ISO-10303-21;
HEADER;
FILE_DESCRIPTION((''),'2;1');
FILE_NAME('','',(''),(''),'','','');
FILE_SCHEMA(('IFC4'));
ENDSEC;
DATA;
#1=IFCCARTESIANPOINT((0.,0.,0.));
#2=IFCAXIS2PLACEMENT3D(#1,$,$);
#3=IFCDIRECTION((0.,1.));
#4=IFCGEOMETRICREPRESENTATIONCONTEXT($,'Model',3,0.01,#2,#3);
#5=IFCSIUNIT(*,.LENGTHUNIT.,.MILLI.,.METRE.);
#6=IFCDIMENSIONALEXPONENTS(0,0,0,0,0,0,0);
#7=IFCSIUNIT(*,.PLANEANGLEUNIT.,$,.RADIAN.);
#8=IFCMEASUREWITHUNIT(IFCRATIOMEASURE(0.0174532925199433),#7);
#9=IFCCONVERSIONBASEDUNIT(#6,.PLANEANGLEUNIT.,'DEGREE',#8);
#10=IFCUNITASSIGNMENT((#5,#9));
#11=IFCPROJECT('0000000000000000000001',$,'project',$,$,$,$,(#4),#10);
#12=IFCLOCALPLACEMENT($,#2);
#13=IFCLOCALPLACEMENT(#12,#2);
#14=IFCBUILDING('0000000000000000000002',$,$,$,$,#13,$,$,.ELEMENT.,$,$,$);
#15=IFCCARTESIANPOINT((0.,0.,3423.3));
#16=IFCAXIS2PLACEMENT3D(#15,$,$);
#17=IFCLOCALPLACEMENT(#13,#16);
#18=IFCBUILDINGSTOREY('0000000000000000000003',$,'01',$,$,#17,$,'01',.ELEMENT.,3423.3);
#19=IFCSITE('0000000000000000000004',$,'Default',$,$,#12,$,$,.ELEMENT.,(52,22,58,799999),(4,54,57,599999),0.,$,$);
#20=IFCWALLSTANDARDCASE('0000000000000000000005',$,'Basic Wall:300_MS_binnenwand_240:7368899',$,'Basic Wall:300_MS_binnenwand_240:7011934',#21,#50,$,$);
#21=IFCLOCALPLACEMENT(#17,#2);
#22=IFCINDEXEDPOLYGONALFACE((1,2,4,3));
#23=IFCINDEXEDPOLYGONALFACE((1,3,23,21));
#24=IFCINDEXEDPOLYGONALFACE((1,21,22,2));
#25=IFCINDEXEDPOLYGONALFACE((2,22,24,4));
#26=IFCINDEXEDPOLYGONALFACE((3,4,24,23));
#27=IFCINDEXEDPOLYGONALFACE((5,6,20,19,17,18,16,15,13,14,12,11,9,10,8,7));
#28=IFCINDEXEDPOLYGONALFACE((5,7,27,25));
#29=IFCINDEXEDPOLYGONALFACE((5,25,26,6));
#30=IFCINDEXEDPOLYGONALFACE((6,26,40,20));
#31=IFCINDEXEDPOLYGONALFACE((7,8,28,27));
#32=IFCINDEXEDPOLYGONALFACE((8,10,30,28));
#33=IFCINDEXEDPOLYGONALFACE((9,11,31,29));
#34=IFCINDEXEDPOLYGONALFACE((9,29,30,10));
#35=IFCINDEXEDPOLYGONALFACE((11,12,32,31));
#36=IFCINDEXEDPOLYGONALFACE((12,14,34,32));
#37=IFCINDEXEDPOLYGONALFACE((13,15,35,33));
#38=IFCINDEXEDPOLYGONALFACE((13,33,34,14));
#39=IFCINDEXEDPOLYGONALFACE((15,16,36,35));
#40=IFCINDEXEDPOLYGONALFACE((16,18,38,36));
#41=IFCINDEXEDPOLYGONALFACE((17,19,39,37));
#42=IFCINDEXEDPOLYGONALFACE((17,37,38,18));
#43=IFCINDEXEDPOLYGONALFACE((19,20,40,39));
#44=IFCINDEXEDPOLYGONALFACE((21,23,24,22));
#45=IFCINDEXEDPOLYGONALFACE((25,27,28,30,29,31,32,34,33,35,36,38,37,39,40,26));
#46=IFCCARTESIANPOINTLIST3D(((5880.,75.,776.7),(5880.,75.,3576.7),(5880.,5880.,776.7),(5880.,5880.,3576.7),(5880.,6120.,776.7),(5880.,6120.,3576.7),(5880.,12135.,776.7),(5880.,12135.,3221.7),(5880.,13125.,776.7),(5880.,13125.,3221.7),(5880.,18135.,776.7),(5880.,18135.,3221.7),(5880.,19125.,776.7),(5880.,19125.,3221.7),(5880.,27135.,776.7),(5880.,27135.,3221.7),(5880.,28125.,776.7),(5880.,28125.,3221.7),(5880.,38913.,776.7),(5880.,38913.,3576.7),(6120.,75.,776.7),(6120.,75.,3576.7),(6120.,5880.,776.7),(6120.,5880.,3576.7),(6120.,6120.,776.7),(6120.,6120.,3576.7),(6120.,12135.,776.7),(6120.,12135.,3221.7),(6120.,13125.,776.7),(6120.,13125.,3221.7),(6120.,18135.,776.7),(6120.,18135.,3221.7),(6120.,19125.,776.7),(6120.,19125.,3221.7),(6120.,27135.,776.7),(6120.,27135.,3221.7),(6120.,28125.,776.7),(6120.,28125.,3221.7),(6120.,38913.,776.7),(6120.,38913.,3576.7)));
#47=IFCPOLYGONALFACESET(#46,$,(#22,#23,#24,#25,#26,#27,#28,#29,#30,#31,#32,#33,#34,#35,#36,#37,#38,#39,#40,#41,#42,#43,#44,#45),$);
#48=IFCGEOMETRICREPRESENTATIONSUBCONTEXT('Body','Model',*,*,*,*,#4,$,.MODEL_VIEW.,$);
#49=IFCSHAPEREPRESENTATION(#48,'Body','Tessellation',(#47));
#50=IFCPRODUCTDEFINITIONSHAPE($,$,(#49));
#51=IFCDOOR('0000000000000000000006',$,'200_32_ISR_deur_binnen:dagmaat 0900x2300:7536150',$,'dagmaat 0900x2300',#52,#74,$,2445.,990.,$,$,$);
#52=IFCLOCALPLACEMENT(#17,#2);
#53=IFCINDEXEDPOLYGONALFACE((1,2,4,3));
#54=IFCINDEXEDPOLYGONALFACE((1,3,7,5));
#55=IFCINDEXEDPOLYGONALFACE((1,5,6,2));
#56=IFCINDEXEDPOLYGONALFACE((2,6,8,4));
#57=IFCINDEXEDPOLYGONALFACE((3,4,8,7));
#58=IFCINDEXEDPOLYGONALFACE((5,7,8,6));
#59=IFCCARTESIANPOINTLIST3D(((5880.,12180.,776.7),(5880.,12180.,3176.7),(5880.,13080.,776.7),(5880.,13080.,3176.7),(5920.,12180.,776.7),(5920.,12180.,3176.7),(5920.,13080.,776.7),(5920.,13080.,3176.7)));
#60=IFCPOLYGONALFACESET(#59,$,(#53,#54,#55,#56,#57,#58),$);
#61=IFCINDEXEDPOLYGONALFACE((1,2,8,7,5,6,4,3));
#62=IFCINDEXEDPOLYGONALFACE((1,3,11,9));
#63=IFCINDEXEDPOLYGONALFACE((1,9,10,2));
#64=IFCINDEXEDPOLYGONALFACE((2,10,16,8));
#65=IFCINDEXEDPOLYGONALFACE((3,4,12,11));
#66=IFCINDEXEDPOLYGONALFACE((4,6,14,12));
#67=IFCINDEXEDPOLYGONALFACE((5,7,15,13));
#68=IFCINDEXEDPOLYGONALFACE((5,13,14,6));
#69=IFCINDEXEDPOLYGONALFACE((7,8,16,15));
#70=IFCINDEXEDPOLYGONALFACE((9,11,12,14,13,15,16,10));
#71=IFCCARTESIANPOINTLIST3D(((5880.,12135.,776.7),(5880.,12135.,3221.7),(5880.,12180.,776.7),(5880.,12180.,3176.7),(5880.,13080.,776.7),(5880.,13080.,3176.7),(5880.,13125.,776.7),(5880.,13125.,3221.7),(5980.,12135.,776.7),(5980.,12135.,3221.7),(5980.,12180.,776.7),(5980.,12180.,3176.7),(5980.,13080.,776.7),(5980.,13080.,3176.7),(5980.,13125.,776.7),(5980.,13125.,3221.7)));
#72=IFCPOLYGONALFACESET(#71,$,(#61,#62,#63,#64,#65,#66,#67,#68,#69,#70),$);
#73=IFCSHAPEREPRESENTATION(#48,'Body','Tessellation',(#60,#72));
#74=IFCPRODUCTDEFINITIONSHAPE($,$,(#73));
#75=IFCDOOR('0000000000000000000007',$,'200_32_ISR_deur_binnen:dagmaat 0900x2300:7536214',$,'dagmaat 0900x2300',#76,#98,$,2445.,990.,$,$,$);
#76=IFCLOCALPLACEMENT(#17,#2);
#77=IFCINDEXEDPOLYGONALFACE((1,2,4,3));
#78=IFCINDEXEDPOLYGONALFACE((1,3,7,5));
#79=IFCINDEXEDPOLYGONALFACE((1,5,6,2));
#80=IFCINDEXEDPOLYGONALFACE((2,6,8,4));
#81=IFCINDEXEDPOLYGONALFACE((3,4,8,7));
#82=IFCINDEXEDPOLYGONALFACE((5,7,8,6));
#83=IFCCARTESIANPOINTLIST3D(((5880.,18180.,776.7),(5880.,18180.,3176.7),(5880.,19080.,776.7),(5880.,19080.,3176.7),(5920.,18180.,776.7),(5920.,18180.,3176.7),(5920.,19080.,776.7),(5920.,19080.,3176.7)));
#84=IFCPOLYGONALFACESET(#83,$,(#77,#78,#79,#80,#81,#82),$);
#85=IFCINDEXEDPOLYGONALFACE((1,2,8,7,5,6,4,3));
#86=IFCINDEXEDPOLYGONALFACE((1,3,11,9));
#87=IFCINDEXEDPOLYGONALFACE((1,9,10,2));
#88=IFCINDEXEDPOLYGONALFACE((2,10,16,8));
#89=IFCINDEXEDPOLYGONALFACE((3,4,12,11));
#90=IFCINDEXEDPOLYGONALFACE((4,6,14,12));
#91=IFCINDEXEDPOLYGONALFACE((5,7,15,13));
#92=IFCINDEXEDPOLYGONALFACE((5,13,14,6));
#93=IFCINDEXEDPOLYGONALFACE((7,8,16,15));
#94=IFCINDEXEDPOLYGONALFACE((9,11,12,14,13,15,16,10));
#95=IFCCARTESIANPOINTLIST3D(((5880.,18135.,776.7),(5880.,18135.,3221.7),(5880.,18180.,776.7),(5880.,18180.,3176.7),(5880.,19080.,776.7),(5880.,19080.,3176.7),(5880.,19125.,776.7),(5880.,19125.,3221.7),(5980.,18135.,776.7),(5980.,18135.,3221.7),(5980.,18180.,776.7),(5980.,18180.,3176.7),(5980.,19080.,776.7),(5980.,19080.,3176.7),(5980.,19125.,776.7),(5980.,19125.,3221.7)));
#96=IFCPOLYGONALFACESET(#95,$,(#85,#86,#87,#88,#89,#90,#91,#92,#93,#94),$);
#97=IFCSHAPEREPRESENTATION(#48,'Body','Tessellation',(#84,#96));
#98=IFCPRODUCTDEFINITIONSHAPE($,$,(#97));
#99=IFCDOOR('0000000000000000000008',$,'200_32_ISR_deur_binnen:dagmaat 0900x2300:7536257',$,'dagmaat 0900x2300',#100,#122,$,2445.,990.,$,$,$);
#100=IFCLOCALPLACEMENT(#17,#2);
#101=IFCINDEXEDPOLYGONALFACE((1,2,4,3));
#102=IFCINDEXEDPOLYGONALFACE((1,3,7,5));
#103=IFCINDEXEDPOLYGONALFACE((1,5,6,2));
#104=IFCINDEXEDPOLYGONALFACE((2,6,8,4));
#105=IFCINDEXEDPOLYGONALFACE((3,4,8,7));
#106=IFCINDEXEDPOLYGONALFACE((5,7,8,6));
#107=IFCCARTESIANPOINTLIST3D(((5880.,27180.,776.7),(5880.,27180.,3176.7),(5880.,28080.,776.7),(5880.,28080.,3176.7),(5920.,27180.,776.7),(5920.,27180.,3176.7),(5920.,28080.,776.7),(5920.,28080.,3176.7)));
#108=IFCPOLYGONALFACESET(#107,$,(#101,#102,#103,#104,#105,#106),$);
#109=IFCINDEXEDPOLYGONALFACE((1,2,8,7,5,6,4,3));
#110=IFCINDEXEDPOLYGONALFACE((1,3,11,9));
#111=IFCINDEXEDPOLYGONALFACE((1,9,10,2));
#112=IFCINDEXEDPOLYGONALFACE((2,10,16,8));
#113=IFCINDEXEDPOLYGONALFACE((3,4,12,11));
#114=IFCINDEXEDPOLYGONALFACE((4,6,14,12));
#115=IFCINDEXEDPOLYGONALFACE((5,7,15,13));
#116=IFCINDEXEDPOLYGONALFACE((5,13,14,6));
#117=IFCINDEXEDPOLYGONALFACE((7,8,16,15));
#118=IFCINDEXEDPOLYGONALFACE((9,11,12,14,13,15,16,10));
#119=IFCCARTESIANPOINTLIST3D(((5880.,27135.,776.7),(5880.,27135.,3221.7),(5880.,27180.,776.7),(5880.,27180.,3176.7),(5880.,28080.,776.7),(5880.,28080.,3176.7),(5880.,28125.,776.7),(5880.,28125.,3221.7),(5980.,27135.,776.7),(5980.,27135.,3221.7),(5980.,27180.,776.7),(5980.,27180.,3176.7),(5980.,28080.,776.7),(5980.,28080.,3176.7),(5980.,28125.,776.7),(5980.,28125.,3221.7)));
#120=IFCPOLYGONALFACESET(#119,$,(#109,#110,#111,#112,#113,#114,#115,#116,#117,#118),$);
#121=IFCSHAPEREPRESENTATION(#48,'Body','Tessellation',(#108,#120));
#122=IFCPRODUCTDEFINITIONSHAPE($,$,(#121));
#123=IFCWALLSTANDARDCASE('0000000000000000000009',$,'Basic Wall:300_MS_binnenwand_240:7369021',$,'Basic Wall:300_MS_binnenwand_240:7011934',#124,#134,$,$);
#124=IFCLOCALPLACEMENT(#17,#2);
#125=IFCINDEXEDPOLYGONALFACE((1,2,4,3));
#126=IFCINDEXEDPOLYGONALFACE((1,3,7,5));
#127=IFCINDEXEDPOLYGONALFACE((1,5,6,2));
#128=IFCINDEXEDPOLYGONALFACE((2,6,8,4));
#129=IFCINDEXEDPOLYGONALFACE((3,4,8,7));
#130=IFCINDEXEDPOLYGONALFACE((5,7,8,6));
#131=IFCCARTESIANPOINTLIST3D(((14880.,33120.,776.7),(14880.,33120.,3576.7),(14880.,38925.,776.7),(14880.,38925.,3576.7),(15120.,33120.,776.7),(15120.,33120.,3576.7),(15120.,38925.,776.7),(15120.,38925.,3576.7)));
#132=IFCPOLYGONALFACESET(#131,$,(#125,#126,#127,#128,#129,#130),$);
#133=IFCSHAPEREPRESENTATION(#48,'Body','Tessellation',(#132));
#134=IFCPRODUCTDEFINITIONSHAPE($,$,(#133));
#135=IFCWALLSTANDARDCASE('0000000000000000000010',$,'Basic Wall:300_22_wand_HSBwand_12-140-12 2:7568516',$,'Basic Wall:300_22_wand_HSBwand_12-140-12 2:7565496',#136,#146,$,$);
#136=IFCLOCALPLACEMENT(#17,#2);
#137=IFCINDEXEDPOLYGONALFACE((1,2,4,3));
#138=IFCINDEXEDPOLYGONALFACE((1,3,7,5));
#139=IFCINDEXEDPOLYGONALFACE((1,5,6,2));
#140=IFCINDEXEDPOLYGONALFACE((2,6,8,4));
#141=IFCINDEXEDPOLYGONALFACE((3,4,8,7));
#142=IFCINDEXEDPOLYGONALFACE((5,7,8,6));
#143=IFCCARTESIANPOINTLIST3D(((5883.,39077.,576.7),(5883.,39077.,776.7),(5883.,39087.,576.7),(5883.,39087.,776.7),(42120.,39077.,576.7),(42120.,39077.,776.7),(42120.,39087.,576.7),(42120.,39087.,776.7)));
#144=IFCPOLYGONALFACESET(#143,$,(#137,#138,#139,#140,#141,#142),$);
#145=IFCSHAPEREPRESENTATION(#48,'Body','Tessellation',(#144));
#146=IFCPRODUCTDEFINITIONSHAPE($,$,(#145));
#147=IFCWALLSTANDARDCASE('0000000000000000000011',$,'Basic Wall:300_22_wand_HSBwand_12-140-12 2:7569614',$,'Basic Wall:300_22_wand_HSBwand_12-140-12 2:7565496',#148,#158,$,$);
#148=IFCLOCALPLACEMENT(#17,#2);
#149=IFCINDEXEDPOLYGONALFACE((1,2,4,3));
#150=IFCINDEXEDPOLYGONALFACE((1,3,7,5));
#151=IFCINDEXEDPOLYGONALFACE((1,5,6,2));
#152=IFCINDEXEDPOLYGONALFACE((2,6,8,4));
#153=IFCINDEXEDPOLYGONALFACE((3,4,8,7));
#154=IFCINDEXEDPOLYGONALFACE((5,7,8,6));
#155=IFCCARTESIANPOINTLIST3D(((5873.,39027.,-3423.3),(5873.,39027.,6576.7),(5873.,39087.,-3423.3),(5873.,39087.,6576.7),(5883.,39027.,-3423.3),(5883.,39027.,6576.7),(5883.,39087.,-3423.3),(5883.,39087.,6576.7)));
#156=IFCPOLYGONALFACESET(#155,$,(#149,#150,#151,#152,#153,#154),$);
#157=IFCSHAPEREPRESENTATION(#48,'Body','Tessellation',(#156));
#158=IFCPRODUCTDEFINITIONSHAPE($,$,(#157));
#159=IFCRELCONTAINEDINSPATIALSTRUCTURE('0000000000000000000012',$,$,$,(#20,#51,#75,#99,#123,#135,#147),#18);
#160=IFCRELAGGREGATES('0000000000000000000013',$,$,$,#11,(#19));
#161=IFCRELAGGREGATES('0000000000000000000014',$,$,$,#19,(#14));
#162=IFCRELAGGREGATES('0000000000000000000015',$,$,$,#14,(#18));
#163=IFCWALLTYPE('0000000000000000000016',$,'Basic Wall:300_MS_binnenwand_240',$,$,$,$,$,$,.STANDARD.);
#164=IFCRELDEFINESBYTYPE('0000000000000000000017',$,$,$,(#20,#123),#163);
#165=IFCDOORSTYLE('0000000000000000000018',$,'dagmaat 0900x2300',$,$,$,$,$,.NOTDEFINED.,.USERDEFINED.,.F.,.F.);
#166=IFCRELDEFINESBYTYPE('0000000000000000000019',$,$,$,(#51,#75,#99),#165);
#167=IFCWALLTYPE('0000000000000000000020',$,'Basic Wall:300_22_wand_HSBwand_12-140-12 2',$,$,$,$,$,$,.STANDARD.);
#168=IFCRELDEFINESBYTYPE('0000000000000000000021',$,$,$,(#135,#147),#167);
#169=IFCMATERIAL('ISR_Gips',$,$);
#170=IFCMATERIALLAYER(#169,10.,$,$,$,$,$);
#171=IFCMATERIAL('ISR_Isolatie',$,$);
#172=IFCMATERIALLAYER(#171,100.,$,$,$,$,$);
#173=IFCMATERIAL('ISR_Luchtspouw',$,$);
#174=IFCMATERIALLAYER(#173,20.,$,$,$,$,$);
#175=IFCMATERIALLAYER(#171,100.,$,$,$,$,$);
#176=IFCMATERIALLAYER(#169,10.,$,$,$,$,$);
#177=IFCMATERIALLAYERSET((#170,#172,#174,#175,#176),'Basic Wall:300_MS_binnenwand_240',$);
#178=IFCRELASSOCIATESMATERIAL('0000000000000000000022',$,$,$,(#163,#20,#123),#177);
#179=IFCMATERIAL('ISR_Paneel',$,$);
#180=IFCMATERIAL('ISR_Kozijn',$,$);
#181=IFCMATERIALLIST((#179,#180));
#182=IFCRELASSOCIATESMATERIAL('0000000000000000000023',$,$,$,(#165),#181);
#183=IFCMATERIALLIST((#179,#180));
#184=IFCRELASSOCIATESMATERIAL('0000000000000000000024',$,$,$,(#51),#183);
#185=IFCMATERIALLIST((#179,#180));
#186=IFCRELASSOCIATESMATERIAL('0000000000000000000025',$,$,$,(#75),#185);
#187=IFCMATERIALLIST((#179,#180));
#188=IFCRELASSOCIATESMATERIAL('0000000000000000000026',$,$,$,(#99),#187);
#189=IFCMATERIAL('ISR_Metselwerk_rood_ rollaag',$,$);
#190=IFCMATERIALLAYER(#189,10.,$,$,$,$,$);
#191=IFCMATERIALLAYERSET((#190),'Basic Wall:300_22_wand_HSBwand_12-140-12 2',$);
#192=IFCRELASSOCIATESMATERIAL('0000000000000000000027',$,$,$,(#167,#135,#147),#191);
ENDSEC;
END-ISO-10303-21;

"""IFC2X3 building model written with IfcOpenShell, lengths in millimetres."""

from ifc_helpers import new_model, entity, si_unit, converted_unit, direction, frame, frame_2d, origin, origin_2d_with_axis, place, context, subcontext, project, spatial, polyline, rectangle, outline, extrude, source, transform, mapped, material, material_list, layer, layer_set, layer_usage, type_object, type_shapes, element, fill, save


model = new_model("IFC2X3")

# Units and contexts
model_context = context("Model", 3, precision=0.01, world=origin(), true_north=direction((0.0, 1.0)))
body_context = subcontext(model_context, "Body", "Model", "MODEL_VIEW")
ifc_project = project(units=[si_unit("LENGTHUNIT", "METRE", prefix="MILLI"), converted_unit("PLANEANGLEUNIT", "DEGREE", entity("IfcRatioMeasure", 0.0174532925199433), si_unit("PLANEANGLEUNIT", "RADIAN"), dimensions=[0, 0, 0, 0, 0, 0, 0])], contexts=[model_context])

# Site, building, storey
site_placement = place(None, origin())
site = spatial("IfcSite", under=ifc_project, at=site_placement, Name="Default", CompositionType="ELEMENT", RefLatitude=(52, 22, 58, 799999), RefLongitude=(4, 54, 57, 599999), RefElevation=0.0)
building_placement = place(site_placement, origin())
building = spatial("IfcBuilding", under=site, at=building_placement, CompositionType="ELEMENT")
storey_placement = place(building_placement, frame((0.0, 0.0, 3423.3)))
storey = spatial("IfcBuildingStorey", under=building, at=storey_placement, Name="01", LongName="01", CompositionType="ELEMENT", Elevation=3423.3)

# Wall, openings, doors
ifc_material_1 = material(Name="ISR_Gips")
ifc_layer_1 = layer(ifc_material_1, 10.0)
ifc_material_2 = material(Name="ISR_Isolatie")
ifc_layer_2 = layer(ifc_material_2, 100.0)
ifc_material_3 = material(Name="ISR_Luchtspouw")
ifc_layer_3 = layer(ifc_material_3, 20.0)
ifc_layer_4 = layer(ifc_material_2, 100.0)
ifc_layer_5 = layer(ifc_material_1, 10.0)
ifc_layer_set_1 = layer_set([ifc_layer_1, ifc_layer_2, ifc_layer_3, ifc_layer_4, ifc_layer_5], Name="Basic Wall:300_MS_binnenwand_240")
ifc_layer_usage_1 = layer_usage(ifc_layer_set_1, "AXIS2", "NEGATIVE", 120.0)
wall_type_1 = type_object("IfcWallType", Name="Basic Wall:300_MS_binnenwand_240", PredefinedType="STANDARD", material=ifc_layer_set_1)
wall_1_placement = place(storey_placement, frame((6000.0, 38913.0, 776.7), z_axis=(0.0, 0.0, 1.0), x_axis=(0.0, -1.0, 0.0)))
wall_1 = element("IfcWallStandardCase", 1, at=wall_1_placement, inside=storey, type_object=wall_type_1, material=ifc_layer_usage_1, Name="Basic Wall:300_MS_binnenwand_240:7368899", ObjectType="Basic Wall:300_MS_binnenwand_240:7011934", context=body_context, shape_type="SweptSolid", body=[
    extrude(rectangle(XDim=38838.0, YDim=240.0, at=frame_2d((19419.0, 0.0), x_axis=(-1.0, 0.0))), origin(), (0.0, 0.0, 1.0), 2800.0),
])
opening_1_placement = place(storey_placement, frame((6000.0, 38913.0, 776.7), z_axis=(0.0, 0.0, 1.0), x_axis=(0.0, -1.0, 0.0)))
element("IfcOpeningElement", 2, at=opening_1_placement, cuts=wall_1, ObjectType="Opening", context=body_context, shape_type="SweptSolid", body=[
    extrude(rectangle(XDim=2800.0, YDim=240.0, at=origin_2d_with_axis()), frame((33033.0, 0.0, 1400.0), z_axis=(-1.0, 0.0, 0.0), x_axis=(0.0, 0.0, 1.0)), (0.0, 0.0, 1.0), 240.0),
])
opening_2_placement = place(wall_1_placement, frame((26778.0, 120.0, 0.0)))
opening_2 = element("IfcOpeningElement", 3, at=opening_2_placement, cuts=wall_1, ObjectType="Opening", context=body_context, shape_type="SweptSolid", body=[
    extrude(rectangle(XDim=2445.0, YDim=990.0, at=frame_2d((1222.5, 495.0), x_axis=(-1.0, 0.0))), frame((0.0, 0.0, 0.0), z_axis=(0.0, -1.0, 0.0), x_axis=(0.0, 0.0, 1.0)), (0.0, 0.0, 1.0), 240.0),
])
opening_3_placement = place(wall_1_placement, frame((20778.0, 120.0, 0.0)))
opening_3 = element("IfcOpeningElement", 4, at=opening_3_placement, cuts=wall_1, ObjectType="Opening", context=body_context, shape_type="SweptSolid", body=[
    extrude(rectangle(XDim=2445.0, YDim=990.0, at=frame_2d((1222.5, 495.0), x_axis=(-1.0, 0.0))), frame((0.0, 0.0, 0.0), z_axis=(0.0, -1.0, 0.0), x_axis=(0.0, 0.0, 1.0)), (0.0, 0.0, 1.0), 240.0),
])
opening_4_placement = place(wall_1_placement, frame((11778.0, 120.0, 0.0)))
opening_4 = element("IfcOpeningElement", 5, at=opening_4_placement, cuts=wall_1, ObjectType="Opening", context=body_context, shape_type="SweptSolid", body=[
    extrude(rectangle(XDim=2445.0, YDim=990.0, at=frame_2d((1222.5, 495.0), x_axis=(-1.0, 0.0))), frame((0.0, 0.0, 0.0), z_axis=(0.0, -1.0, 0.0), x_axis=(0.0, 0.0, 1.0)), (0.0, 0.0, 1.0), 240.0),
])
ifc_material_4 = material(Name="ISR_Paneel")
ifc_material_5 = material(Name="ISR_Kozijn")
ifc_material_list_1 = material_list([ifc_material_4, ifc_material_5])
ifc_material_list_2 = material_list([ifc_material_4, ifc_material_5])
door_style = type_object("IfcDoorStyle", Name="dagmaat 0900x2300", ConstructionType="USERDEFINED", OperationType="NOTDEFINED", ParameterTakesPrecedence=False, Sizeable=False, material=ifc_material_list_2)
shared_shape_1 = source(origin(), body_context, "Body", "SweptSolid", [
    extrude(rectangle(XDim=900.0, YDim=40.0, at=origin_2d_with_axis()), frame((495.0, 220.0, 0.0)), (0.0, 0.0, 1.0), 2400.0),
    extrude(outline(polyline([(-1211.2, -450.0), (-1211.2, -495.0), (1233.7, -495.0), (1233.7, 495.0), (-1211.2, 495.0), (-1211.2, 450.0), (1188.8, 450.0), (1188.8, -450.0), (-1211.2, -450.0)])), frame((495.0, 140.0, 1211.2), z_axis=(0.0, -1.0, 0.0), x_axis=(0.0, 0.0, 1.0)), (0.0, 0.0, -1.0), 100.0),
])
type_shapes(door_style, [shared_shape_1])
door_1_placement = place(opening_2_placement, frame((0.0, 0.0, 0.0), z_axis=(0.0, 0.0, 1.0), x_axis=(-1.0, 0.0, 0.0)))
door_1 = element("IfcDoor", 6, at=door_1_placement, inside=storey, type_object=door_style, material=ifc_material_list_1, Name="200_32_ISR_deur_binnen:dagmaat 0900x2300:7536150", ObjectType="dagmaat 0900x2300", OverallHeight=2445.0, OverallWidth=990.0, context=body_context, shape_type="MappedRepresentation", body=[
    mapped(shared_shape_1, transform((0.0, 0.0, 0.0), scale=1.0)),
])
fill(opening_2, door_1)
ifc_material_list_3 = material_list([ifc_material_4, ifc_material_5])
door_2_placement = place(opening_3_placement, frame((0.0, 0.0, 0.0), z_axis=(0.0, 0.0, 1.0), x_axis=(-1.0, 0.0, 0.0)))
door_2 = element("IfcDoor", 7, at=door_2_placement, inside=storey, type_object=door_style, material=ifc_material_list_3, Name="200_32_ISR_deur_binnen:dagmaat 0900x2300:7536214", ObjectType="dagmaat 0900x2300", OverallHeight=2445.0, OverallWidth=990.0, context=body_context, shape_type="MappedRepresentation", body=[
    mapped(shared_shape_1, transform((0.0, 0.0, 0.0), scale=1.0)),
])
fill(opening_3, door_2)
ifc_material_list_4 = material_list([ifc_material_4, ifc_material_5])
door_3_placement = place(opening_4_placement, frame((0.0, 0.0, 0.0), z_axis=(0.0, 0.0, 1.0), x_axis=(-1.0, 0.0, 0.0)))
door_3 = element("IfcDoor", 8, at=door_3_placement, inside=storey, type_object=door_style, material=ifc_material_list_4, Name="200_32_ISR_deur_binnen:dagmaat 0900x2300:7536257", ObjectType="dagmaat 0900x2300", OverallHeight=2445.0, OverallWidth=990.0, context=body_context, shape_type="MappedRepresentation", body=[
    mapped(shared_shape_1, transform((0.0, 0.0, 0.0), scale=1.0)),
])
fill(opening_4, door_3)

# Walls
ifc_layer_usage_2 = layer_usage(ifc_layer_set_1, "AXIS2", "POSITIVE", -120.0)
wall_2_placement = place(storey_placement, frame((15000.0, 33120.0, 776.7), z_axis=(0.0, 0.0, 1.0), x_axis=(0.0, 1.0, 0.0)))
element("IfcWallStandardCase", 9, at=wall_2_placement, inside=storey, type_object=wall_type_1, material=ifc_layer_usage_2, Name="Basic Wall:300_MS_binnenwand_240:7369021", ObjectType="Basic Wall:300_MS_binnenwand_240:7011934", context=body_context, shape_type="SweptSolid", body=[
    extrude(rectangle(XDim=5805.0, YDim=240.0, at=frame_2d((2902.5, 0.0), x_axis=(-1.0, 0.0))), origin(), (0.0, 0.0, 1.0), 2800.0),
])
ifc_material_6 = material(Name="ISR_Metselwerk_rood_ rollaag")
ifc_layer_6 = layer(ifc_material_6, 10.0)
ifc_layer_set_2 = layer_set([ifc_layer_6], Name="Basic Wall:300_22_wand_HSBwand_12-140-12 2")
ifc_layer_usage_3 = layer_usage(ifc_layer_set_2, "AXIS2", "NEGATIVE", 5.0)
wall_type_2 = type_object("IfcWallType", Name="Basic Wall:300_22_wand_HSBwand_12-140-12 2", PredefinedType="STANDARD", material=ifc_layer_set_2)
wall_3_placement = place(storey_placement, frame((5883.0, 39082.0, 576.7)))
element("IfcWallStandardCase", 10, at=wall_3_placement, inside=storey, type_object=wall_type_2, material=ifc_layer_usage_3, Name="Basic Wall:300_22_wand_HSBwand_12-140-12 2:7568516", ObjectType="Basic Wall:300_22_wand_HSBwand_12-140-12 2:7565496", context=body_context, shape_type="SweptSolid", body=[
    extrude(rectangle(XDim=36237.0, YDim=10.0, at=frame_2d((18118.5, 0.0), x_axis=(-1.0, 0.0))), origin(), (0.0, 0.0, 1.0), 200.0),
])
ifc_layer_usage_4 = layer_usage(ifc_layer_set_2, "AXIS2", "NEGATIVE", 5.0)
wall_4_placement = place(storey_placement, frame((5878.0, 39027.0, -3423.3), z_axis=(0.0, 0.0, 1.0), x_axis=(0.0, 1.0, 0.0)))
element("IfcWallStandardCase", 11, at=wall_4_placement, inside=storey, type_object=wall_type_2, material=ifc_layer_usage_4, Name="Basic Wall:300_22_wand_HSBwand_12-140-12 2:7569614", ObjectType="Basic Wall:300_22_wand_HSBwand_12-140-12 2:7565496", context=body_context, shape_type="SweptSolid", body=[
    extrude(rectangle(XDim=60.0, YDim=10.0, at=frame_2d((30.0, 0.0), x_axis=(-1.0, 0.0))), origin(), (0.0, 0.0, 1.0), 10000.0),
])

save(model, "model.ifc")
